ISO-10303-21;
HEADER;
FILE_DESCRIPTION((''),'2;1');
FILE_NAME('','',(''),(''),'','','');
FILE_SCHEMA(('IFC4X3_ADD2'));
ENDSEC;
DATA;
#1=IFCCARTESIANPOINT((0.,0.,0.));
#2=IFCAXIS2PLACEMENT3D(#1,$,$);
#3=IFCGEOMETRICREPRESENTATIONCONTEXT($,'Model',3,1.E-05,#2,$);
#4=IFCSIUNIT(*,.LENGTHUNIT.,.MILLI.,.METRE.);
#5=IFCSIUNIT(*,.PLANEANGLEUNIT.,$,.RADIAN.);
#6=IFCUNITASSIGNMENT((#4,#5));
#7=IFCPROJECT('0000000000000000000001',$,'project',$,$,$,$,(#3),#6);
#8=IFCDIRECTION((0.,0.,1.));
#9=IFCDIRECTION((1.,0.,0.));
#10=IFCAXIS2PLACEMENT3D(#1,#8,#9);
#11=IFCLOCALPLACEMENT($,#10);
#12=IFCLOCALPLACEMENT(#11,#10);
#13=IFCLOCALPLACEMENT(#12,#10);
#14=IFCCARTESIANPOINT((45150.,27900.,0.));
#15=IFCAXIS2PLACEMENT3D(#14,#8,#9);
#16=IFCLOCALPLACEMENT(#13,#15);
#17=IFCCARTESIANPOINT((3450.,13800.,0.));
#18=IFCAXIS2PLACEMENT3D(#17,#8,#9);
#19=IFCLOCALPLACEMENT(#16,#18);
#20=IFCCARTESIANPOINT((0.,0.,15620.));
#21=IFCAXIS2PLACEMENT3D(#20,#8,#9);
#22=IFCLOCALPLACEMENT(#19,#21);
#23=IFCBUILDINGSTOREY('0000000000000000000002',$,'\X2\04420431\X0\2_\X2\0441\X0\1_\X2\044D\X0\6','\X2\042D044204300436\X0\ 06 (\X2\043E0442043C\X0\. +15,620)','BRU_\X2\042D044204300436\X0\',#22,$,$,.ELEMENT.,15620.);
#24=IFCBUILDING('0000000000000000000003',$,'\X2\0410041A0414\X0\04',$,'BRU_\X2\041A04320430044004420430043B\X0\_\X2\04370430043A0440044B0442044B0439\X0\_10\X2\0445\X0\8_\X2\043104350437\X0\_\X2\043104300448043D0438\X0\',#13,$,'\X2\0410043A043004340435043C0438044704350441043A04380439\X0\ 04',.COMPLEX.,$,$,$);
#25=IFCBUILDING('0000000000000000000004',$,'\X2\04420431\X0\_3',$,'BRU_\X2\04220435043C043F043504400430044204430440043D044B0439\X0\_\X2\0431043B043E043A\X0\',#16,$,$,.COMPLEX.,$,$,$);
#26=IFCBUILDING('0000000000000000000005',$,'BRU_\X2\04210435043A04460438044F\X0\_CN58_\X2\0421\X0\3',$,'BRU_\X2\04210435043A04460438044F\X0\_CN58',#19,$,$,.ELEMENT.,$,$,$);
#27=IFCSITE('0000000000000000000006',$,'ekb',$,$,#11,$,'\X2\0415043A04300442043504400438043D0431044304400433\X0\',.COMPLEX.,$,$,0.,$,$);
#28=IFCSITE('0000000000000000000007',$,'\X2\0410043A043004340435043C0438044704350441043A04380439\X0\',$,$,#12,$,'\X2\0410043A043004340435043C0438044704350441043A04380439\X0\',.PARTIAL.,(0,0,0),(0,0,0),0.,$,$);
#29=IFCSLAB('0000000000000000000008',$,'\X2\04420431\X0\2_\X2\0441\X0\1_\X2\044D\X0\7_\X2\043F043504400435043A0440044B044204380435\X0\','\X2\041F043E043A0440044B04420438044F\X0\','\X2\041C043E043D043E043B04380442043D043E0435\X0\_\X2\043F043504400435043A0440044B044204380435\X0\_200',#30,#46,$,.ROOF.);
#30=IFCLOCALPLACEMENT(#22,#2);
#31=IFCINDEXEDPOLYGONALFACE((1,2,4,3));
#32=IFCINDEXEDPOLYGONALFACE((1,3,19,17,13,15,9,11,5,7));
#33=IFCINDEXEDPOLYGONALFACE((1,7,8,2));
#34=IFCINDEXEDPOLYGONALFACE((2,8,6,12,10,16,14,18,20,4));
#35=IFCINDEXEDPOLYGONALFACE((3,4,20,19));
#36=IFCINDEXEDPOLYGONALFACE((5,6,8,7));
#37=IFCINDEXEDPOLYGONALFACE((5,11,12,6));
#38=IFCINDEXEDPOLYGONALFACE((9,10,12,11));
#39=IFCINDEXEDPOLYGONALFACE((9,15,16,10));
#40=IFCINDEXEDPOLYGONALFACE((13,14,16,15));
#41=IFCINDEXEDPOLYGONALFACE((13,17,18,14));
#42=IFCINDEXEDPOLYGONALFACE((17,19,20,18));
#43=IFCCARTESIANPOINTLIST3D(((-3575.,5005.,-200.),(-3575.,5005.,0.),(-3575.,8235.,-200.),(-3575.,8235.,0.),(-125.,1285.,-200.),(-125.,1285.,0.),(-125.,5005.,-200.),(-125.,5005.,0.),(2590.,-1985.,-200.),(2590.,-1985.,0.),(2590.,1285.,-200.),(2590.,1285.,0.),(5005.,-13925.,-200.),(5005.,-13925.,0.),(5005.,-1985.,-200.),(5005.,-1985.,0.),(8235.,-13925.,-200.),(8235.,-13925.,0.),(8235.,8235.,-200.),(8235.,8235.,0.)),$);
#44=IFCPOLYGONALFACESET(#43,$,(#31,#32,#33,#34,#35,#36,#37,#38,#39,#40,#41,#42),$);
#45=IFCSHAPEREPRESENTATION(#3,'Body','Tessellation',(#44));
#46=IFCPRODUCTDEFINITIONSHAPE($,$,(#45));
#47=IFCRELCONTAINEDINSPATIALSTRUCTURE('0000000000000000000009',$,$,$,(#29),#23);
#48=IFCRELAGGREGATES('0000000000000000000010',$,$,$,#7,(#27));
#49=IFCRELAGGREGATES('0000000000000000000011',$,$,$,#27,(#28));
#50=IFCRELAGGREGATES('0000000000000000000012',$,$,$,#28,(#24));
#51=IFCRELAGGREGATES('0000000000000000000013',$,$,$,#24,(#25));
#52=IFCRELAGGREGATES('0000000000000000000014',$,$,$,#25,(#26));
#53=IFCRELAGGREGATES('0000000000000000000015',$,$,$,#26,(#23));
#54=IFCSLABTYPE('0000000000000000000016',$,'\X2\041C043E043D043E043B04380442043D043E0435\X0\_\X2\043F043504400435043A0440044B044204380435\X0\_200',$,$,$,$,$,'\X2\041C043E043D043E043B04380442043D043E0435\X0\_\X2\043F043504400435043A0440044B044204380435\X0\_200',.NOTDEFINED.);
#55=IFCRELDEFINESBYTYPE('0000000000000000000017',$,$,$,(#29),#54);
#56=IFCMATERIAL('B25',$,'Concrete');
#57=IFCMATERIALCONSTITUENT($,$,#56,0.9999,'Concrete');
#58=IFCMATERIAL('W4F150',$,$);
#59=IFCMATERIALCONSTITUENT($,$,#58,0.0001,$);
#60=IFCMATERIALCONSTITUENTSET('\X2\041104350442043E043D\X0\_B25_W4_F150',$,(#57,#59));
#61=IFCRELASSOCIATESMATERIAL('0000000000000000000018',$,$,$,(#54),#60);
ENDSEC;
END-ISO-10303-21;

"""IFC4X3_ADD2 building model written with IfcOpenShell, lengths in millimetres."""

from ifc_helpers import new_model, si_unit, frame, origin, origin_with_axes, place, context, project, spatial, polyline, outline, extrude, material, constituent, constituent_set, type_object, element, save


model = new_model("IFC4X3_ADD2")

# Units and contexts
model_context = context("Model", 3, precision=1e-05, world=origin())
ifc_project = project(units=[si_unit("LENGTHUNIT", "METRE", prefix="MILLI"), si_unit("PLANEANGLEUNIT", "RADIAN")], contexts=[model_context])

# Sites, buildings, storey
site_1_placement = place(None, origin_with_axes())
site_1 = spatial("IfcSite", under=ifc_project, at=site_1_placement, Name="ekb", LongName="Екатеринбург", CompositionType="COMPLEX", RefElevation=0.0)
site_2_placement = place(site_1_placement, origin_with_axes())
site_2 = spatial("IfcSite", under=site_1, at=site_2_placement, Name="Академический", LongName="Академический", CompositionType="PARTIAL", RefLatitude=(0, 0, 0), RefLongitude=(0, 0, 0), RefElevation=0.0)
building_1_placement = place(site_2_placement, origin_with_axes())
building_1 = spatial("IfcBuilding", under=site_2, at=building_1_placement, Name="АКД04", ObjectType="BRU_Квартал_закрытый_10х8_без_башни", LongName="Академический 04", CompositionType="COMPLEX")
building_2_placement = place(building_1_placement, frame((45150.0, 27900.0, 0.0), z_axis=(0.0, 0.0, 1.0), x_axis=(1.0, 0.0, 0.0)))
building_2 = spatial("IfcBuilding", under=building_1, at=building_2_placement, Name="тб_3", ObjectType="BRU_Температурный_блок", CompositionType="COMPLEX")
building_3_placement = place(building_2_placement, frame((3450.0, 13800.0, 0.0), z_axis=(0.0, 0.0, 1.0), x_axis=(1.0, 0.0, 0.0)))
building_3 = spatial("IfcBuilding", under=building_2, at=building_3_placement, Name="BRU_Секция_CN58_С3", ObjectType="BRU_Секция_CN58", CompositionType="ELEMENT")
storey_placement = place(building_3_placement, frame((0.0, 0.0, 15620.0), z_axis=(0.0, 0.0, 1.0), x_axis=(1.0, 0.0, 0.0)))
storey = spatial("IfcBuildingStorey", under=building_3, at=storey_placement, Name="тб2_с1_э6", Description="Этаж 06 (отм. +15,620)", ObjectType="BRU_Этаж", CompositionType="ELEMENT", Elevation=15620.0)

# Slab
ifc_material_1 = material(Name="B25", Category="Concrete")
ifc_constituent_1 = constituent(ifc_material_1, Category="Concrete", fraction=0.9999)
ifc_material_2 = material(Name="W4F150")
ifc_constituent_2 = constituent(ifc_material_2, fraction=0.0001)
ifc_constituent_set = constituent_set(constituents=[ifc_constituent_1, ifc_constituent_2], Name="Бетон_B25_W4_F150")
slab_type = type_object("IfcSlabType", Name="Монолитное_перекрытие_200", ElementType="Монолитное_перекрытие_200", PredefinedType="NOTDEFINED", material=ifc_constituent_set)
slab_placement = place(storey_placement, frame((0.0, 0.0, -200.0), z_axis=(0.0, 0.0, 1.0), x_axis=(1.0, 0.0, 0.0)))
element("IfcSlab", 1, at=slab_placement, inside=storey, type_object=slab_type, Name="тб2_с1_э7_перекрытие", Description="Покрытия", ObjectType="Монолитное_перекрытие_200", PredefinedType="ROOF", context=model_context, shape_type="SweptSolid", body=[
    extrude(outline(polyline([(8235.0, 8235.0), (8235.0, -13925.0), (5005.0, -13925.0), (5005.0, -1985.0), (2590.0, -1985.0), (2590.0, 1285.0), (-125.0, 1285.0), (-125.0, 5005.0), (-3575.0, 5005.0), (-3575.0, 8235.0), (8235.0, 8235.0)])), origin_with_axes(), (0.0, 0.0, 1.0), 200.0),
])

save(model, "model.ifc")
